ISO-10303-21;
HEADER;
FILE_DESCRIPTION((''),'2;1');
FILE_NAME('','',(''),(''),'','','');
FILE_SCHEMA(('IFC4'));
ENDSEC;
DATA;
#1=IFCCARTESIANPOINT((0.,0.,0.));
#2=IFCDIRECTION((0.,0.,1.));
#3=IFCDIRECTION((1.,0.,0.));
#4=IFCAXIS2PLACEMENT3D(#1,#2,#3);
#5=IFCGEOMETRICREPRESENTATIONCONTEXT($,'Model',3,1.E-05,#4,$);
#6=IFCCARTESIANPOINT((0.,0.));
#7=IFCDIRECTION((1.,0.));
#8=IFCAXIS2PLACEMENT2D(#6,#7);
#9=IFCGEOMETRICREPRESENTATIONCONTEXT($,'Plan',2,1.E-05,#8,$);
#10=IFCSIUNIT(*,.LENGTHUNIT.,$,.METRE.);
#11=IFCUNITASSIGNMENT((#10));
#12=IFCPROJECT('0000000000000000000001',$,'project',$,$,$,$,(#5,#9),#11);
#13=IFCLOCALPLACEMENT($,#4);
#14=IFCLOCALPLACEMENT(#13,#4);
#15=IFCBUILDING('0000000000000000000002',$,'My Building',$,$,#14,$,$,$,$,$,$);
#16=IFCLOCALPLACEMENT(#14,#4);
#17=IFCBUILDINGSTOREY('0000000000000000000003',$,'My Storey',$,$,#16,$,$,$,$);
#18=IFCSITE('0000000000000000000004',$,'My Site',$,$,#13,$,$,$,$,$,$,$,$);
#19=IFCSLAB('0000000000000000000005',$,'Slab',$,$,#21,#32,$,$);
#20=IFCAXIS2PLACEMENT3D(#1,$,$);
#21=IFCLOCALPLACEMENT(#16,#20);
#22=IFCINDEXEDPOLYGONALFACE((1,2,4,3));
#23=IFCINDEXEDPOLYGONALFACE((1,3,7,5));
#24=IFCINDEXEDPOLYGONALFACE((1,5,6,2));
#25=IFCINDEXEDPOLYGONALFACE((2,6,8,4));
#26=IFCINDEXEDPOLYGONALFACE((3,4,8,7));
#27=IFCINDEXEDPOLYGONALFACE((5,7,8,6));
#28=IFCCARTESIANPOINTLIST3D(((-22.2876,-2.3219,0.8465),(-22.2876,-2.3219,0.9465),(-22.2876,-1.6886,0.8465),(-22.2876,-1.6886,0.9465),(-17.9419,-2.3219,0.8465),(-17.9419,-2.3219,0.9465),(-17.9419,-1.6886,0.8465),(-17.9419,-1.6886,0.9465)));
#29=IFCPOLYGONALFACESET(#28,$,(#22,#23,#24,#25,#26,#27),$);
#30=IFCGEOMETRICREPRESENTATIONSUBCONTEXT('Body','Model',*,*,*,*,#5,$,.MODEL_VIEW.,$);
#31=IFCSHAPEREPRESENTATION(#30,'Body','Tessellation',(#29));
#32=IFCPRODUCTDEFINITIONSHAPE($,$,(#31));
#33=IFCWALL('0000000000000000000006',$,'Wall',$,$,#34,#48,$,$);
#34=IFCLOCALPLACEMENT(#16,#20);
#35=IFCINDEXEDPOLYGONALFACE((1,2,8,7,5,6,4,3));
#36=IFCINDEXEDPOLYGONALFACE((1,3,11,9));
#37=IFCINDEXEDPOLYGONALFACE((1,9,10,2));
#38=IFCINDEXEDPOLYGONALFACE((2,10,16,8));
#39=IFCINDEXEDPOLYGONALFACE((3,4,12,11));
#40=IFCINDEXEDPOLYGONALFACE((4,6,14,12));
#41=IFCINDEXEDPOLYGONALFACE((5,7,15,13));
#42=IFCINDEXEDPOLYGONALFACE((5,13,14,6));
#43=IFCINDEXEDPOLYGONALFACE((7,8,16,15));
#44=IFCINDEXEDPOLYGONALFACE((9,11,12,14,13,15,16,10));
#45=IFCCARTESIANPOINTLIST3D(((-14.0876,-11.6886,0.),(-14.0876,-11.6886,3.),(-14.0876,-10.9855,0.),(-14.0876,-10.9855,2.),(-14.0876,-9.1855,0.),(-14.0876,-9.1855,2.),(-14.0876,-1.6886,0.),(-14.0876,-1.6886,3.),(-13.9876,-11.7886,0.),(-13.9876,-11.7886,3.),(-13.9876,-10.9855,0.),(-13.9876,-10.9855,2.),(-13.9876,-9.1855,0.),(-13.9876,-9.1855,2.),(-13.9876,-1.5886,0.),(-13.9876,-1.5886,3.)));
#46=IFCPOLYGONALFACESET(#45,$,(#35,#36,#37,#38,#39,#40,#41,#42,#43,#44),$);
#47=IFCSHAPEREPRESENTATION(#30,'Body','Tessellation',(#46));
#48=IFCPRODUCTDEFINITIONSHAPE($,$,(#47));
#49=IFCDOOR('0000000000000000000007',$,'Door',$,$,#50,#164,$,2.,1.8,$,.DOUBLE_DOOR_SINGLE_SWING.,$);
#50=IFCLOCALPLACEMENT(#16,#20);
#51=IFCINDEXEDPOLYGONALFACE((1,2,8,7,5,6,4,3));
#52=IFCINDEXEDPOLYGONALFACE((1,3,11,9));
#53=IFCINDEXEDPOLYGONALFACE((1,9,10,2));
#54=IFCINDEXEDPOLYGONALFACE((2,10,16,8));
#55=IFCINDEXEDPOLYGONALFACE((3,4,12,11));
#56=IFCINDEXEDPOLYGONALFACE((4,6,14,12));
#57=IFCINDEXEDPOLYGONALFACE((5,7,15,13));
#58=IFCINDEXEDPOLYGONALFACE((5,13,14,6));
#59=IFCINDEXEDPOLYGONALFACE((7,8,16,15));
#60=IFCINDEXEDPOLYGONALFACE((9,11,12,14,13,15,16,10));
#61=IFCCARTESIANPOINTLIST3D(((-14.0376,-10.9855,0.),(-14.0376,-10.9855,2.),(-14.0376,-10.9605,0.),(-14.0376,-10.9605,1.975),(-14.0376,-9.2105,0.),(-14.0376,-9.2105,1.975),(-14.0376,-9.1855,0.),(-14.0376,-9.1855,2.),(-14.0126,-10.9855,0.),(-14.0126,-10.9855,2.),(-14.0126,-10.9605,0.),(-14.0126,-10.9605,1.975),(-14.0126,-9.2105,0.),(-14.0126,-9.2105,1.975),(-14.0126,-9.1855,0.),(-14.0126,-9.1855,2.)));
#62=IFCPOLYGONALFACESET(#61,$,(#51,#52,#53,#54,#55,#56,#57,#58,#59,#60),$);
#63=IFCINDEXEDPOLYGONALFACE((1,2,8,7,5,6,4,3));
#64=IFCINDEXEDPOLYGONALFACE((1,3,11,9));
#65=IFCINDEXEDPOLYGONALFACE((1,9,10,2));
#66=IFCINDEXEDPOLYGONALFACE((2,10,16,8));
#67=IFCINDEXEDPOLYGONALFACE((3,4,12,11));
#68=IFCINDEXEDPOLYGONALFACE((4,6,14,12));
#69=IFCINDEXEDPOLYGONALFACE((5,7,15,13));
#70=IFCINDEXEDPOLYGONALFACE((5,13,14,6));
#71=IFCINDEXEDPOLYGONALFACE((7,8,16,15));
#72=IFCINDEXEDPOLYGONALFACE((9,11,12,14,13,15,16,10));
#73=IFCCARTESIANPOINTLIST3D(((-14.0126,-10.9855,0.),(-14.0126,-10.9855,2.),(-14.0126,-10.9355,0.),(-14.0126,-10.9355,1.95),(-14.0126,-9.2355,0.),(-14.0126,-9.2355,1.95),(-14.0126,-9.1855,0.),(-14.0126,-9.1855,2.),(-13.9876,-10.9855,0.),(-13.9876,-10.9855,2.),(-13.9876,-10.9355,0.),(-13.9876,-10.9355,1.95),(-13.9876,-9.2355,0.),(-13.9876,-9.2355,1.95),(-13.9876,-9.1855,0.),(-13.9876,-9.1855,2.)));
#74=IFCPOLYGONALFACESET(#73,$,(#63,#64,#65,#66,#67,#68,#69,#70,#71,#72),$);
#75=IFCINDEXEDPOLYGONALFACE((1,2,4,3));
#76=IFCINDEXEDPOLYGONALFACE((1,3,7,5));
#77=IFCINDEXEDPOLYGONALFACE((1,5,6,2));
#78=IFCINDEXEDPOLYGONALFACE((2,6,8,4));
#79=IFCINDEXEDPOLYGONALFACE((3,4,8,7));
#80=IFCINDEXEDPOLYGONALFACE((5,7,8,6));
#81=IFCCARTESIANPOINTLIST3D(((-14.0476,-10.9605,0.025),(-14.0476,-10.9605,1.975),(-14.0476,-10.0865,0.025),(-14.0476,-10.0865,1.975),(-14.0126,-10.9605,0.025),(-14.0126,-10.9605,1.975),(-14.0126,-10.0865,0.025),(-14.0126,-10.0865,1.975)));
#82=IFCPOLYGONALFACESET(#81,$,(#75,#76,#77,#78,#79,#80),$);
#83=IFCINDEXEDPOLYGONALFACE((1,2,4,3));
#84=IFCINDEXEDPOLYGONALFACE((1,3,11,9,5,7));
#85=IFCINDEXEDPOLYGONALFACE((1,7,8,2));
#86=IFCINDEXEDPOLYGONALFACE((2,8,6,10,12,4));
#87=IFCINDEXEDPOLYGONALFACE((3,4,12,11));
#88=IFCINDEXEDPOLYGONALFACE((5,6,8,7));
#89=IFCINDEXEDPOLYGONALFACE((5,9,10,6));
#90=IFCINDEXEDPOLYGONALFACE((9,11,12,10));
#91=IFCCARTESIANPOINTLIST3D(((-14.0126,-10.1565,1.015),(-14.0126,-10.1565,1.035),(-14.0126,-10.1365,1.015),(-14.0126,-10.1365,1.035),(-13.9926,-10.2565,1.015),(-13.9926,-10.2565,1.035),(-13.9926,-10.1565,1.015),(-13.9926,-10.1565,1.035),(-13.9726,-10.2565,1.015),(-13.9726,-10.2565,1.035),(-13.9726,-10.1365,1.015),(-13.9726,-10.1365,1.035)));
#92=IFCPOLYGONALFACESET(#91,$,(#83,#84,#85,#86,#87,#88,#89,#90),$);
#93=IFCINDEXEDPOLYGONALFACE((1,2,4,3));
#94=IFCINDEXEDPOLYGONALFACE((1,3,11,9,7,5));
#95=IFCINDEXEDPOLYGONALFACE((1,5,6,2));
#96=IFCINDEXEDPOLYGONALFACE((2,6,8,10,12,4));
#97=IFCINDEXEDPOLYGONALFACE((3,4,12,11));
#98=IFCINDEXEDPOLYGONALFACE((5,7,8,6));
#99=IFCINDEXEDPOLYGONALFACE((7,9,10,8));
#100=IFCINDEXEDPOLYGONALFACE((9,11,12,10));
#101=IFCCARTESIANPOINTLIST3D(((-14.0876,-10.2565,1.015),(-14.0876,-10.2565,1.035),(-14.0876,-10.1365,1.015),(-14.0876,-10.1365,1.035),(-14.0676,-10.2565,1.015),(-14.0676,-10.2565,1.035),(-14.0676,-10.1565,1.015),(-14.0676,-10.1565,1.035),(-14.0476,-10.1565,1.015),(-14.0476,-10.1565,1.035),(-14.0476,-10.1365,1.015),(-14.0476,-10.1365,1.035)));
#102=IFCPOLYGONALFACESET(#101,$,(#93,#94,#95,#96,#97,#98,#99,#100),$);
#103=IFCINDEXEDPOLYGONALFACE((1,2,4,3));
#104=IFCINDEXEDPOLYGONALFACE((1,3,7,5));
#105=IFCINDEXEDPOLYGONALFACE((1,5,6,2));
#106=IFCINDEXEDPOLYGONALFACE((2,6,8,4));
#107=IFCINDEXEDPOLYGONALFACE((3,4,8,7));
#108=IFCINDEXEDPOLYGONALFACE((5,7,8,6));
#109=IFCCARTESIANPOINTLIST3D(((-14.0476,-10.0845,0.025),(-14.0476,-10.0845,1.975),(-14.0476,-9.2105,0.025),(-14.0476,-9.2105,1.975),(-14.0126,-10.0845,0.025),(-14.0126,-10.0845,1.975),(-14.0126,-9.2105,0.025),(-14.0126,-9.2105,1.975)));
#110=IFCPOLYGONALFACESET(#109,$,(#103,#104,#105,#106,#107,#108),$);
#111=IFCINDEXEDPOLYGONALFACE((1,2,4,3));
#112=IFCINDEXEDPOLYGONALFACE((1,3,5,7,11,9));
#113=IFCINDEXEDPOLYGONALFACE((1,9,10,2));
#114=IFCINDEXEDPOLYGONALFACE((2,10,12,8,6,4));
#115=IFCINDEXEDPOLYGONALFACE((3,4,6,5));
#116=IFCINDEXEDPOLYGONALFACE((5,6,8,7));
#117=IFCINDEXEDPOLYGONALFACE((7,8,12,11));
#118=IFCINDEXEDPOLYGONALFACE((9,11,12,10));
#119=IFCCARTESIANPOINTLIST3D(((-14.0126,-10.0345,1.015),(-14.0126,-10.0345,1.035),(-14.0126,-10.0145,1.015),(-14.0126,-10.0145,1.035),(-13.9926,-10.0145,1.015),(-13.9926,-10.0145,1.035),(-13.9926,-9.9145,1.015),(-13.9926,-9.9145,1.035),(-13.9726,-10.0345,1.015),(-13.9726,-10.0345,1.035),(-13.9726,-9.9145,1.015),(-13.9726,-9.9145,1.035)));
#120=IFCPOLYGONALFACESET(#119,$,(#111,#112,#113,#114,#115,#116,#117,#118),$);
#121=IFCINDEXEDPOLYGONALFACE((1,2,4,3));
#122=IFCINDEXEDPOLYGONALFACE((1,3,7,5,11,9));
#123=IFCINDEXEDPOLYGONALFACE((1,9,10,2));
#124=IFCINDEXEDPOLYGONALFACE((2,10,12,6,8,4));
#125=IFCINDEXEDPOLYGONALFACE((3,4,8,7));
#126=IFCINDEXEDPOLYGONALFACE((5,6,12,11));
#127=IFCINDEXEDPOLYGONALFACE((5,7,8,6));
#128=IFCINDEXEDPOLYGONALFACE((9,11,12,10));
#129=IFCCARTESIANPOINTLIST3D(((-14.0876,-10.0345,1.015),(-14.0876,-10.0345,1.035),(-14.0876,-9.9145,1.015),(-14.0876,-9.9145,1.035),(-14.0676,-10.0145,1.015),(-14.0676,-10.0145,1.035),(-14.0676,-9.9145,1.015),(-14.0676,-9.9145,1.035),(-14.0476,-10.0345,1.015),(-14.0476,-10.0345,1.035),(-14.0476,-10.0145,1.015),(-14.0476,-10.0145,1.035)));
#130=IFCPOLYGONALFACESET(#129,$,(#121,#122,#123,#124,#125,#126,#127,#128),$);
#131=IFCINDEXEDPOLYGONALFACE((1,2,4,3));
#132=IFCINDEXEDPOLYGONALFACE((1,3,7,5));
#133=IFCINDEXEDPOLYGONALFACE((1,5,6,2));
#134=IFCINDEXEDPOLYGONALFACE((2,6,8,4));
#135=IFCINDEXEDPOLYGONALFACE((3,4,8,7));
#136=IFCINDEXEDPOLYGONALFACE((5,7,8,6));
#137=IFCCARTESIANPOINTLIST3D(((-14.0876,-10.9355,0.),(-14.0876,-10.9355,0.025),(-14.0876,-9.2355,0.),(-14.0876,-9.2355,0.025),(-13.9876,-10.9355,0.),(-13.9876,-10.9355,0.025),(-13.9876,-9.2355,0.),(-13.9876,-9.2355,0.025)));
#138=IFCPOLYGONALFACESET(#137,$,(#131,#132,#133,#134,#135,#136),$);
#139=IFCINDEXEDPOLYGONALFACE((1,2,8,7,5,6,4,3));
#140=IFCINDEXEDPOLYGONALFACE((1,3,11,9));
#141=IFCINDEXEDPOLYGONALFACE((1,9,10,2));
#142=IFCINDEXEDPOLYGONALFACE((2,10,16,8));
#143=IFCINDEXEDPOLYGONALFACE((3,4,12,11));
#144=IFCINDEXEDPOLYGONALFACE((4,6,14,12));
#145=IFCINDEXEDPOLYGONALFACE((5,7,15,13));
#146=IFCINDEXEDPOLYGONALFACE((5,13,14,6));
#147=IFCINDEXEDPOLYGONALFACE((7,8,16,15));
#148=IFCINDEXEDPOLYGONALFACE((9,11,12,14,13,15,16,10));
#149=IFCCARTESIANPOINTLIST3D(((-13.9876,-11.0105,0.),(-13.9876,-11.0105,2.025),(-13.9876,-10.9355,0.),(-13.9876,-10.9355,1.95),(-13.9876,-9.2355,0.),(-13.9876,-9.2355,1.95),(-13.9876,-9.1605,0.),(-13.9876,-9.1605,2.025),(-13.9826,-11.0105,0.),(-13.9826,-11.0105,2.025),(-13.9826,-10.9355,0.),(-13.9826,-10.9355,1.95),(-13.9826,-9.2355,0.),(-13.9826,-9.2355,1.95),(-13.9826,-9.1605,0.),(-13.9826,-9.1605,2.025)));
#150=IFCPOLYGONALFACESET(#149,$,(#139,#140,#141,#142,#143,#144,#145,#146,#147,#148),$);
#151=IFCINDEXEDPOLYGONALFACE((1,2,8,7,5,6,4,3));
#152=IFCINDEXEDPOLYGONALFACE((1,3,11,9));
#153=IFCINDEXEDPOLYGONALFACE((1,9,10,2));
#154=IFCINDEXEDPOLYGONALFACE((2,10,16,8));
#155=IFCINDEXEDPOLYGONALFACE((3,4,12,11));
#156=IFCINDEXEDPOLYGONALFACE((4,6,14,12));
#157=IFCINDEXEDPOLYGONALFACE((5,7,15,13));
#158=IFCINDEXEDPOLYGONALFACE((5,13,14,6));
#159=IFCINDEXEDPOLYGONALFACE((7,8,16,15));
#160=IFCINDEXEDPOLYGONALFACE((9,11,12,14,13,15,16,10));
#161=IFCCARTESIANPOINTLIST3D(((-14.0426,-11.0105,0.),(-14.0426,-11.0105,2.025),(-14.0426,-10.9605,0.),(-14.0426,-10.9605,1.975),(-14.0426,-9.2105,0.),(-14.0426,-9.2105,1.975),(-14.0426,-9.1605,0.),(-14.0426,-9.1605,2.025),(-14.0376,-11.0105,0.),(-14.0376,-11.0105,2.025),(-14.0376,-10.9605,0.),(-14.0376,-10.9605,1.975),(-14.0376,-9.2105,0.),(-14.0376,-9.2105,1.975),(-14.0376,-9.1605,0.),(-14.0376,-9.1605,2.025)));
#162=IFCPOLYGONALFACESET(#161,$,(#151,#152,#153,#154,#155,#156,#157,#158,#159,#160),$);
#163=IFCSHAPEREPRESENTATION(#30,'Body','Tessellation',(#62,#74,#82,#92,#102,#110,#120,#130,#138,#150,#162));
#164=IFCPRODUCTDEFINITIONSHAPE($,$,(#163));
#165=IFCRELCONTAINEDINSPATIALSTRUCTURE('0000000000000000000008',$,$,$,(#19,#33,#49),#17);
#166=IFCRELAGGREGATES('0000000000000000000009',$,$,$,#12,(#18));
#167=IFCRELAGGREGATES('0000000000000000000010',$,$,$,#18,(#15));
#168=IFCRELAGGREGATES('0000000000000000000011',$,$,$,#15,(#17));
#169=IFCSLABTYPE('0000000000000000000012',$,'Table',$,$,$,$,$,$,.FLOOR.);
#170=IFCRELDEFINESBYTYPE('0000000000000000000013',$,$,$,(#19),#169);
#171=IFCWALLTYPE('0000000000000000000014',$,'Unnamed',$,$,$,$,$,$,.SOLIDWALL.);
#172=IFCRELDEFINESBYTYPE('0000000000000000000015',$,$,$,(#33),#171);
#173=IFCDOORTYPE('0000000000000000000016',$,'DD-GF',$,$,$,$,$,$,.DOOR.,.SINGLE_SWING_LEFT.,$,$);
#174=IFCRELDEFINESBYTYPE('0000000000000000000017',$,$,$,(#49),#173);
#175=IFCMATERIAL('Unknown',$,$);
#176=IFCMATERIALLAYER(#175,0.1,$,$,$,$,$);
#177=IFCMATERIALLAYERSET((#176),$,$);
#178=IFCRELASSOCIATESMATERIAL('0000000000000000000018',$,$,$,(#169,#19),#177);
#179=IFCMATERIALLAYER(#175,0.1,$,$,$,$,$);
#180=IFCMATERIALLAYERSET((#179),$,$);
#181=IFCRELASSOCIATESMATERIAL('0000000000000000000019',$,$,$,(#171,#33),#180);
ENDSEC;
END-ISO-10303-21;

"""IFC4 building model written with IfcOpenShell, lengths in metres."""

from ifc_helpers import new_model, entity, si_unit, frame, origin_with_axes, origin_2d_with_axis, place, context, subcontext, project, spatial, line, indexed_curve, outline, extrude, shape, source, transform, mapped, material, layer, layer_set, layer_usage, type_object, type_shapes, element, fill, save


model = new_model("IFC4")

# Units and contexts
model_context = context("Model", 3, precision=1e-05, world=origin_with_axes())
plan_context = context("Plan", 2, precision=1e-05, world=origin_2d_with_axis())
body_context_1 = subcontext(model_context, "Body", "Model", "MODEL_VIEW")
body_context_2 = subcontext(plan_context, "Body", "Plan", "PLAN_VIEW")
ifc_project = project(units=[si_unit("LENGTHUNIT", "METRE")], contexts=[model_context, plan_context])

# Site, building, storey
site_placement = place(None, origin_with_axes())
site = spatial("IfcSite", under=ifc_project, at=site_placement, Name="My Site")
building_placement = place(site_placement, origin_with_axes())
building = spatial("IfcBuilding", under=site, at=building_placement, Name="My Building")
storey_placement = place(building_placement, origin_with_axes())
storey = spatial("IfcBuildingStorey", under=building, at=storey_placement, Name="My Storey")

# Shared definitions
ifc_material = material(Name="Unknown")

# Slab
ifc_layer_1 = layer(ifc_material, 0.1)
ifc_layer_set_1 = layer_set([ifc_layer_1])
slab_type_1 = type_object("IfcSlabType", Name="Table", PredefinedType="FLOOR", material=ifc_layer_set_1)
ifc_layer_usage_1 = layer_usage(ifc_layer_set_1, "AXIS3", "POSITIVE", -0.1)
slab_1_placement = place(storey_placement, frame((-17.9419, -1.6886, 0.9465), z_axis=(0.0, 0.0, 1.0), x_axis=(0.0, -1.0, 0.0)))
element("IfcSlab", 1, at=slab_1_placement, inside=storey, type_object=slab_type_1, material=ifc_layer_usage_1, Name="Slab", context=body_context_1, shape_type="SweptSolid", body=[
    extrude(outline(indexed_curve([(0.0, 0.0), (0.6332, 0.0), (0.6332, -4.3456), (0.0, -4.3456), (0.0, 0.0)])), frame((0.0, 0.0, -0.1), z_axis=(0.0, 0.0, 1.0), x_axis=(1.0, 0.0, 0.0)), (0.0, 0.0, 1.0), 0.1),
])

# Shared definitions
ifc_layer_2 = layer(ifc_material, 0.1)
ifc_layer_set_2 = layer_set([ifc_layer_2])
wall_type = type_object("IfcWallType", Name="Unnamed", PredefinedType="SOLIDWALL", material=ifc_layer_set_2)

# Shared definitions
shared_shape_1 = source(origin_with_axes(), body_context_1, "Body", "SweptSolid", [
    extrude(outline(indexed_curve([(0.0, 0.0), (1.8, 0.0), (1.8, 2.0), (0.0, 2.0)], segments=[line(1, 2, 3, 4, 1)])), frame((0.0, -0.6, 0.0), z_axis=(0.0, -1.0, 0.0), x_axis=(1.0, 0.0, 0.0)), (0.0, 0.0, -1.0), 1.2),
])
door_type = type_object("IfcDoorType", Name="DD-GF", OperationType="SINGLE_SWING_LEFT", PredefinedType="DOOR")
shared_shape_2 = source(origin_with_axes(), body_context_1, "Body", "SweptSolid", [
    extrude(outline(indexed_curve([(0.0, 0.0), (0.0, 2.0), (1.8, 2.0), (1.8, 0.0), (1.775, 0.0), (1.775, 1.975), (0.025, 1.975), (0.025, 0.0)], segments=[line(1, 2, 3, 4, 5, 6, 7, 8, 1)])), frame((0.0, 0.025, 0.0), z_axis=(0.0, -1.0, 0.0), x_axis=(1.0, 0.0, 0.0)), (0.0, 0.0, -1.0), 0.025),
    extrude(outline(indexed_curve([(0.0, 0.0), (0.0, 2.0), (1.8, 2.0), (1.8, 0.0), (1.75, 0.0), (1.75, 1.95), (0.05, 1.95), (0.05, 0.0)], segments=[line(1, 2, 3, 4, 5, 6, 7, 8, 1)])), frame((0.0, 0.0, 0.0), z_axis=(0.0, -1.0, 0.0), x_axis=(1.0, 0.0, 0.0)), (0.0, 0.0, -1.0), 0.025),
    extrude(outline(indexed_curve([(0.0, 0.0), (0.874, 0.0), (0.874, 0.035), (0.0, 0.035)], segments=[line(1, 2, 3, 4, 1)])), frame((0.025, 0.025, 0.025), z_axis=(0.0, 0.0, 1.0), x_axis=(1.0, 0.0, 0.0)), (0.0, 0.0, 1.0), 1.95),
    extrude(outline(indexed_curve([(0.0, 0.0), (0.0, -0.04), (-0.12, -0.04), (-0.12, -0.02), (-0.02, -0.02), (-0.02, 0.0)], segments=[line(1, 2, 3, 4, 5, 6, 1)])), frame((0.849, 0.025, 1.015), z_axis=(0.0, 0.0, 1.0), x_axis=(1.0, 0.0, 0.0)), (0.0, 0.0, 1.0), 0.02),
    extrude(outline(indexed_curve([(0.0, 0.0), (0.0, 0.04), (-0.12, 0.04), (-0.12, 0.02), (-0.02, 0.02), (-0.02, 0.0)], segments=[line(1, 2, 3, 4, 5, 6, 1)])), frame((0.849, 0.06, 1.015), z_axis=(0.0, 0.0, 1.0), x_axis=(1.0, 0.0, 0.0)), (0.0, 0.0, 1.0), 0.02),
    extrude(outline(indexed_curve([(0.0, 0.0), (-0.874, 0.0), (-0.874, 0.035), (0.0, 0.035)], segments=[line(1, 2, 3, 4, 1)])), frame((1.775, 0.025, 0.025), z_axis=(0.0, 0.0, 1.0), x_axis=(1.0, 0.0, 0.0)), (0.0, 0.0, 1.0), 1.95),
    extrude(outline(indexed_curve([(0.0, 0.0), (0.0, -0.04), (0.12, -0.04), (0.12, -0.02), (0.02, -0.02), (0.02, 0.0)], segments=[line(1, 2, 3, 4, 5, 6, 1)])), frame((0.951, 0.025, 1.015), z_axis=(0.0, 0.0, 1.0), x_axis=(1.0, 0.0, 0.0)), (0.0, 0.0, 1.0), 0.02),
    extrude(outline(indexed_curve([(0.0, 0.0), (0.0, 0.04), (0.12, 0.04), (0.12, 0.02), (0.02, 0.02), (0.02, 0.0)], segments=[line(1, 2, 3, 4, 5, 6, 1)])), frame((0.951, 0.06, 1.015), z_axis=(0.0, 0.0, 1.0), x_axis=(1.0, 0.0, 0.0)), (0.0, 0.0, 1.0), 0.02),
    extrude(outline(indexed_curve([(0.0, 0.0), (1.7, 0.0), (1.7, 0.1), (0.0, 0.1)], segments=[line(1, 2, 3, 4, 1)])), frame((0.05, 0.0, 0.0), z_axis=(0.0, 0.0, 1.0), x_axis=(1.0, 0.0, 0.0)), (0.0, 0.0, 1.0), 0.025),
    extrude(outline(indexed_curve([(0.0, 0.0), (0.0, 2.025), (1.85, 2.025), (1.85, 0.0), (1.775, 0.0), (1.775, 1.95), (0.075, 1.95), (0.075, 0.0)], segments=[line(1, 2, 3, 4, 5, 6, 7, 8, 1)])), frame((-0.025, -0.005, 0.0), z_axis=(0.0, -1.0, 0.0), x_axis=(1.0, 0.0, 0.0)), (0.0, 0.0, -1.0), 0.005),
    extrude(outline(indexed_curve([(0.0, 0.0), (0.0, 2.025), (1.85, 2.025), (1.85, 0.0), (1.8, 0.0), (1.8, 1.975), (0.05, 1.975), (0.05, 0.0)], segments=[line(1, 2, 3, 4, 5, 6, 7, 8, 1)])), frame((-0.025, 0.05, 0.0), z_axis=(0.0, -1.0, 0.0), x_axis=(1.0, 0.0, 0.0)), (0.0, 0.0, -1.0), 0.005),
])
shared_shape_3 = source(origin_with_axes(), body_context_2, "Body", "Curve2D", [
    entity("IfcIndexedPolyCurve", entity("IfcCartesianPointList2D", [[0.0, 0.0], [0.0, 0.05], [0.025, 0.05], [0.025, 0.025], [0.05, 0.025], [0.05, 0.0]]), [entity("IfcLineIndex", [1, 2, 3, 4, 5, 6, 1])]),
    entity("IfcIndexedPolyCurve", entity("IfcCartesianPointList2D", [[1.8, 0.0], [1.8, 0.05], [1.775, 0.05], [1.775, 0.025], [1.75, 0.025], [1.75, 0.0]]), [entity("IfcLineIndex", [1, 2, 3, 4, 5, 6, 1])]),
    entity("IfcTrimmedCurve", entity("IfcEllipse", entity("IfcAxis2Placement2D", entity("IfcCartesianPoint", [0.06, 0.05]), entity("IfcDirection", [1.0, 0.0])), 0.84, 0.875), [entity("IfcCartesianPoint", [0.9, 0.05])], [entity("IfcCartesianPoint", [0.06, 0.925])], True, "CARTESIAN"),
    entity("IfcIndexedPolyCurve", entity("IfcCartesianPointList2D", [[0.025, 0.05], [0.06, 0.05], [0.06, 0.925], [0.025, 0.925]]), [entity("IfcLineIndex", [1, 2, 3, 4, 1])]),
    entity("IfcTrimmedCurve", entity("IfcEllipse", entity("IfcAxis2Placement2D", entity("IfcCartesianPoint", [1.74, 0.05]), entity("IfcDirection", [1.0, 0.0])), 0.84, 0.875), [entity("IfcCartesianPoint", [1.74, 0.925])], [entity("IfcCartesianPoint", [0.9, 0.05])], True, "CARTESIAN"),
    entity("IfcIndexedPolyCurve", entity("IfcCartesianPointList2D", [[1.775, 0.05], [1.74, 0.05], [1.74, 0.925], [1.775, 0.925]]), [entity("IfcLineIndex", [1, 2, 3, 4, 1])]),
])
type_shapes(door_type, [shared_shape_2, shared_shape_3])

# Wall, opening, door
ifc_layer_usage_2 = layer_usage(ifc_layer_set_2, "AXIS2", "POSITIVE", 0.0)
wall_1_placement = place(storey_placement, frame((-14.0876, -1.6886, 0.0), z_axis=(0.0, 0.0, 1.0), x_axis=(0.0, -1.0, 0.0)))
wall_1 = element("IfcWall", 2, at=wall_1_placement, inside=storey, type_object=wall_type, material=ifc_layer_usage_2, Name="Wall", context=body_context_1, shape_type="SweptSolid", body=[
    extrude(outline(indexed_curve([(0.0, 0.0), (-0.1, 0.1), (10.1, 0.1), (10.0, 0.0)], segments=[line(1, 2, 3, 4, 1)])), origin_with_axes(), (0.0, 0.0, 1.0), 3.0),
])
opening_1_placement = place(wall_1_placement, frame((9.2969, 0.1, 0.0), z_axis=(0.0, 0.0, 1.0), x_axis=(-1.0, 0.0, 0.0)))
opening_1 = element("IfcOpeningElement", 3, at=opening_1_placement, cuts=wall_1, PredefinedType="OPENING", context=body_context_1, shape_type="MappedRepresentation", body=[
    mapped(shared_shape_1, transform((0.0, 0.0, 0.0), x_axis=(1.0, 0.0, 0.0), y_axis=(0.0, 1.0, 0.0), z_axis=(0.0, 0.0, 1.0), scale=1.0)),
])
door_1_placement = place(opening_1_placement, frame((0.0, 0.0, 0.0), z_axis=(0.0, 0.0, 1.0), x_axis=(1.0, 0.0, 0.0)))
door_1 = element("IfcDoor", 4, at=door_1_placement, inside=storey, type_object=door_type, Name="Door", OperationType="DOUBLE_DOOR_SINGLE_SWING", OverallHeight=2.0, OverallWidth=1.8, shapes=[
    shape(body_context_1, "Body", "MappedRepresentation", [mapped(shared_shape_2, transform((0.0, 0.0, 0.0), x_axis=(1.0, 0.0, 0.0), y_axis=(0.0, 1.0, 0.0), z_axis=(0.0, 0.0, 1.0), scale=1.0))]),
    shape(body_context_2, "Body", "MappedRepresentation", [mapped(shared_shape_3, transform((0.0, 0.0, 0.0), x_axis=(1.0, 0.0, 0.0), y_axis=(0.0, 1.0, 0.0), z_axis=(0.0, 0.0, 1.0), scale=1.0))]),
])
fill(opening_1, door_1)

save(model, "model.ifc")
